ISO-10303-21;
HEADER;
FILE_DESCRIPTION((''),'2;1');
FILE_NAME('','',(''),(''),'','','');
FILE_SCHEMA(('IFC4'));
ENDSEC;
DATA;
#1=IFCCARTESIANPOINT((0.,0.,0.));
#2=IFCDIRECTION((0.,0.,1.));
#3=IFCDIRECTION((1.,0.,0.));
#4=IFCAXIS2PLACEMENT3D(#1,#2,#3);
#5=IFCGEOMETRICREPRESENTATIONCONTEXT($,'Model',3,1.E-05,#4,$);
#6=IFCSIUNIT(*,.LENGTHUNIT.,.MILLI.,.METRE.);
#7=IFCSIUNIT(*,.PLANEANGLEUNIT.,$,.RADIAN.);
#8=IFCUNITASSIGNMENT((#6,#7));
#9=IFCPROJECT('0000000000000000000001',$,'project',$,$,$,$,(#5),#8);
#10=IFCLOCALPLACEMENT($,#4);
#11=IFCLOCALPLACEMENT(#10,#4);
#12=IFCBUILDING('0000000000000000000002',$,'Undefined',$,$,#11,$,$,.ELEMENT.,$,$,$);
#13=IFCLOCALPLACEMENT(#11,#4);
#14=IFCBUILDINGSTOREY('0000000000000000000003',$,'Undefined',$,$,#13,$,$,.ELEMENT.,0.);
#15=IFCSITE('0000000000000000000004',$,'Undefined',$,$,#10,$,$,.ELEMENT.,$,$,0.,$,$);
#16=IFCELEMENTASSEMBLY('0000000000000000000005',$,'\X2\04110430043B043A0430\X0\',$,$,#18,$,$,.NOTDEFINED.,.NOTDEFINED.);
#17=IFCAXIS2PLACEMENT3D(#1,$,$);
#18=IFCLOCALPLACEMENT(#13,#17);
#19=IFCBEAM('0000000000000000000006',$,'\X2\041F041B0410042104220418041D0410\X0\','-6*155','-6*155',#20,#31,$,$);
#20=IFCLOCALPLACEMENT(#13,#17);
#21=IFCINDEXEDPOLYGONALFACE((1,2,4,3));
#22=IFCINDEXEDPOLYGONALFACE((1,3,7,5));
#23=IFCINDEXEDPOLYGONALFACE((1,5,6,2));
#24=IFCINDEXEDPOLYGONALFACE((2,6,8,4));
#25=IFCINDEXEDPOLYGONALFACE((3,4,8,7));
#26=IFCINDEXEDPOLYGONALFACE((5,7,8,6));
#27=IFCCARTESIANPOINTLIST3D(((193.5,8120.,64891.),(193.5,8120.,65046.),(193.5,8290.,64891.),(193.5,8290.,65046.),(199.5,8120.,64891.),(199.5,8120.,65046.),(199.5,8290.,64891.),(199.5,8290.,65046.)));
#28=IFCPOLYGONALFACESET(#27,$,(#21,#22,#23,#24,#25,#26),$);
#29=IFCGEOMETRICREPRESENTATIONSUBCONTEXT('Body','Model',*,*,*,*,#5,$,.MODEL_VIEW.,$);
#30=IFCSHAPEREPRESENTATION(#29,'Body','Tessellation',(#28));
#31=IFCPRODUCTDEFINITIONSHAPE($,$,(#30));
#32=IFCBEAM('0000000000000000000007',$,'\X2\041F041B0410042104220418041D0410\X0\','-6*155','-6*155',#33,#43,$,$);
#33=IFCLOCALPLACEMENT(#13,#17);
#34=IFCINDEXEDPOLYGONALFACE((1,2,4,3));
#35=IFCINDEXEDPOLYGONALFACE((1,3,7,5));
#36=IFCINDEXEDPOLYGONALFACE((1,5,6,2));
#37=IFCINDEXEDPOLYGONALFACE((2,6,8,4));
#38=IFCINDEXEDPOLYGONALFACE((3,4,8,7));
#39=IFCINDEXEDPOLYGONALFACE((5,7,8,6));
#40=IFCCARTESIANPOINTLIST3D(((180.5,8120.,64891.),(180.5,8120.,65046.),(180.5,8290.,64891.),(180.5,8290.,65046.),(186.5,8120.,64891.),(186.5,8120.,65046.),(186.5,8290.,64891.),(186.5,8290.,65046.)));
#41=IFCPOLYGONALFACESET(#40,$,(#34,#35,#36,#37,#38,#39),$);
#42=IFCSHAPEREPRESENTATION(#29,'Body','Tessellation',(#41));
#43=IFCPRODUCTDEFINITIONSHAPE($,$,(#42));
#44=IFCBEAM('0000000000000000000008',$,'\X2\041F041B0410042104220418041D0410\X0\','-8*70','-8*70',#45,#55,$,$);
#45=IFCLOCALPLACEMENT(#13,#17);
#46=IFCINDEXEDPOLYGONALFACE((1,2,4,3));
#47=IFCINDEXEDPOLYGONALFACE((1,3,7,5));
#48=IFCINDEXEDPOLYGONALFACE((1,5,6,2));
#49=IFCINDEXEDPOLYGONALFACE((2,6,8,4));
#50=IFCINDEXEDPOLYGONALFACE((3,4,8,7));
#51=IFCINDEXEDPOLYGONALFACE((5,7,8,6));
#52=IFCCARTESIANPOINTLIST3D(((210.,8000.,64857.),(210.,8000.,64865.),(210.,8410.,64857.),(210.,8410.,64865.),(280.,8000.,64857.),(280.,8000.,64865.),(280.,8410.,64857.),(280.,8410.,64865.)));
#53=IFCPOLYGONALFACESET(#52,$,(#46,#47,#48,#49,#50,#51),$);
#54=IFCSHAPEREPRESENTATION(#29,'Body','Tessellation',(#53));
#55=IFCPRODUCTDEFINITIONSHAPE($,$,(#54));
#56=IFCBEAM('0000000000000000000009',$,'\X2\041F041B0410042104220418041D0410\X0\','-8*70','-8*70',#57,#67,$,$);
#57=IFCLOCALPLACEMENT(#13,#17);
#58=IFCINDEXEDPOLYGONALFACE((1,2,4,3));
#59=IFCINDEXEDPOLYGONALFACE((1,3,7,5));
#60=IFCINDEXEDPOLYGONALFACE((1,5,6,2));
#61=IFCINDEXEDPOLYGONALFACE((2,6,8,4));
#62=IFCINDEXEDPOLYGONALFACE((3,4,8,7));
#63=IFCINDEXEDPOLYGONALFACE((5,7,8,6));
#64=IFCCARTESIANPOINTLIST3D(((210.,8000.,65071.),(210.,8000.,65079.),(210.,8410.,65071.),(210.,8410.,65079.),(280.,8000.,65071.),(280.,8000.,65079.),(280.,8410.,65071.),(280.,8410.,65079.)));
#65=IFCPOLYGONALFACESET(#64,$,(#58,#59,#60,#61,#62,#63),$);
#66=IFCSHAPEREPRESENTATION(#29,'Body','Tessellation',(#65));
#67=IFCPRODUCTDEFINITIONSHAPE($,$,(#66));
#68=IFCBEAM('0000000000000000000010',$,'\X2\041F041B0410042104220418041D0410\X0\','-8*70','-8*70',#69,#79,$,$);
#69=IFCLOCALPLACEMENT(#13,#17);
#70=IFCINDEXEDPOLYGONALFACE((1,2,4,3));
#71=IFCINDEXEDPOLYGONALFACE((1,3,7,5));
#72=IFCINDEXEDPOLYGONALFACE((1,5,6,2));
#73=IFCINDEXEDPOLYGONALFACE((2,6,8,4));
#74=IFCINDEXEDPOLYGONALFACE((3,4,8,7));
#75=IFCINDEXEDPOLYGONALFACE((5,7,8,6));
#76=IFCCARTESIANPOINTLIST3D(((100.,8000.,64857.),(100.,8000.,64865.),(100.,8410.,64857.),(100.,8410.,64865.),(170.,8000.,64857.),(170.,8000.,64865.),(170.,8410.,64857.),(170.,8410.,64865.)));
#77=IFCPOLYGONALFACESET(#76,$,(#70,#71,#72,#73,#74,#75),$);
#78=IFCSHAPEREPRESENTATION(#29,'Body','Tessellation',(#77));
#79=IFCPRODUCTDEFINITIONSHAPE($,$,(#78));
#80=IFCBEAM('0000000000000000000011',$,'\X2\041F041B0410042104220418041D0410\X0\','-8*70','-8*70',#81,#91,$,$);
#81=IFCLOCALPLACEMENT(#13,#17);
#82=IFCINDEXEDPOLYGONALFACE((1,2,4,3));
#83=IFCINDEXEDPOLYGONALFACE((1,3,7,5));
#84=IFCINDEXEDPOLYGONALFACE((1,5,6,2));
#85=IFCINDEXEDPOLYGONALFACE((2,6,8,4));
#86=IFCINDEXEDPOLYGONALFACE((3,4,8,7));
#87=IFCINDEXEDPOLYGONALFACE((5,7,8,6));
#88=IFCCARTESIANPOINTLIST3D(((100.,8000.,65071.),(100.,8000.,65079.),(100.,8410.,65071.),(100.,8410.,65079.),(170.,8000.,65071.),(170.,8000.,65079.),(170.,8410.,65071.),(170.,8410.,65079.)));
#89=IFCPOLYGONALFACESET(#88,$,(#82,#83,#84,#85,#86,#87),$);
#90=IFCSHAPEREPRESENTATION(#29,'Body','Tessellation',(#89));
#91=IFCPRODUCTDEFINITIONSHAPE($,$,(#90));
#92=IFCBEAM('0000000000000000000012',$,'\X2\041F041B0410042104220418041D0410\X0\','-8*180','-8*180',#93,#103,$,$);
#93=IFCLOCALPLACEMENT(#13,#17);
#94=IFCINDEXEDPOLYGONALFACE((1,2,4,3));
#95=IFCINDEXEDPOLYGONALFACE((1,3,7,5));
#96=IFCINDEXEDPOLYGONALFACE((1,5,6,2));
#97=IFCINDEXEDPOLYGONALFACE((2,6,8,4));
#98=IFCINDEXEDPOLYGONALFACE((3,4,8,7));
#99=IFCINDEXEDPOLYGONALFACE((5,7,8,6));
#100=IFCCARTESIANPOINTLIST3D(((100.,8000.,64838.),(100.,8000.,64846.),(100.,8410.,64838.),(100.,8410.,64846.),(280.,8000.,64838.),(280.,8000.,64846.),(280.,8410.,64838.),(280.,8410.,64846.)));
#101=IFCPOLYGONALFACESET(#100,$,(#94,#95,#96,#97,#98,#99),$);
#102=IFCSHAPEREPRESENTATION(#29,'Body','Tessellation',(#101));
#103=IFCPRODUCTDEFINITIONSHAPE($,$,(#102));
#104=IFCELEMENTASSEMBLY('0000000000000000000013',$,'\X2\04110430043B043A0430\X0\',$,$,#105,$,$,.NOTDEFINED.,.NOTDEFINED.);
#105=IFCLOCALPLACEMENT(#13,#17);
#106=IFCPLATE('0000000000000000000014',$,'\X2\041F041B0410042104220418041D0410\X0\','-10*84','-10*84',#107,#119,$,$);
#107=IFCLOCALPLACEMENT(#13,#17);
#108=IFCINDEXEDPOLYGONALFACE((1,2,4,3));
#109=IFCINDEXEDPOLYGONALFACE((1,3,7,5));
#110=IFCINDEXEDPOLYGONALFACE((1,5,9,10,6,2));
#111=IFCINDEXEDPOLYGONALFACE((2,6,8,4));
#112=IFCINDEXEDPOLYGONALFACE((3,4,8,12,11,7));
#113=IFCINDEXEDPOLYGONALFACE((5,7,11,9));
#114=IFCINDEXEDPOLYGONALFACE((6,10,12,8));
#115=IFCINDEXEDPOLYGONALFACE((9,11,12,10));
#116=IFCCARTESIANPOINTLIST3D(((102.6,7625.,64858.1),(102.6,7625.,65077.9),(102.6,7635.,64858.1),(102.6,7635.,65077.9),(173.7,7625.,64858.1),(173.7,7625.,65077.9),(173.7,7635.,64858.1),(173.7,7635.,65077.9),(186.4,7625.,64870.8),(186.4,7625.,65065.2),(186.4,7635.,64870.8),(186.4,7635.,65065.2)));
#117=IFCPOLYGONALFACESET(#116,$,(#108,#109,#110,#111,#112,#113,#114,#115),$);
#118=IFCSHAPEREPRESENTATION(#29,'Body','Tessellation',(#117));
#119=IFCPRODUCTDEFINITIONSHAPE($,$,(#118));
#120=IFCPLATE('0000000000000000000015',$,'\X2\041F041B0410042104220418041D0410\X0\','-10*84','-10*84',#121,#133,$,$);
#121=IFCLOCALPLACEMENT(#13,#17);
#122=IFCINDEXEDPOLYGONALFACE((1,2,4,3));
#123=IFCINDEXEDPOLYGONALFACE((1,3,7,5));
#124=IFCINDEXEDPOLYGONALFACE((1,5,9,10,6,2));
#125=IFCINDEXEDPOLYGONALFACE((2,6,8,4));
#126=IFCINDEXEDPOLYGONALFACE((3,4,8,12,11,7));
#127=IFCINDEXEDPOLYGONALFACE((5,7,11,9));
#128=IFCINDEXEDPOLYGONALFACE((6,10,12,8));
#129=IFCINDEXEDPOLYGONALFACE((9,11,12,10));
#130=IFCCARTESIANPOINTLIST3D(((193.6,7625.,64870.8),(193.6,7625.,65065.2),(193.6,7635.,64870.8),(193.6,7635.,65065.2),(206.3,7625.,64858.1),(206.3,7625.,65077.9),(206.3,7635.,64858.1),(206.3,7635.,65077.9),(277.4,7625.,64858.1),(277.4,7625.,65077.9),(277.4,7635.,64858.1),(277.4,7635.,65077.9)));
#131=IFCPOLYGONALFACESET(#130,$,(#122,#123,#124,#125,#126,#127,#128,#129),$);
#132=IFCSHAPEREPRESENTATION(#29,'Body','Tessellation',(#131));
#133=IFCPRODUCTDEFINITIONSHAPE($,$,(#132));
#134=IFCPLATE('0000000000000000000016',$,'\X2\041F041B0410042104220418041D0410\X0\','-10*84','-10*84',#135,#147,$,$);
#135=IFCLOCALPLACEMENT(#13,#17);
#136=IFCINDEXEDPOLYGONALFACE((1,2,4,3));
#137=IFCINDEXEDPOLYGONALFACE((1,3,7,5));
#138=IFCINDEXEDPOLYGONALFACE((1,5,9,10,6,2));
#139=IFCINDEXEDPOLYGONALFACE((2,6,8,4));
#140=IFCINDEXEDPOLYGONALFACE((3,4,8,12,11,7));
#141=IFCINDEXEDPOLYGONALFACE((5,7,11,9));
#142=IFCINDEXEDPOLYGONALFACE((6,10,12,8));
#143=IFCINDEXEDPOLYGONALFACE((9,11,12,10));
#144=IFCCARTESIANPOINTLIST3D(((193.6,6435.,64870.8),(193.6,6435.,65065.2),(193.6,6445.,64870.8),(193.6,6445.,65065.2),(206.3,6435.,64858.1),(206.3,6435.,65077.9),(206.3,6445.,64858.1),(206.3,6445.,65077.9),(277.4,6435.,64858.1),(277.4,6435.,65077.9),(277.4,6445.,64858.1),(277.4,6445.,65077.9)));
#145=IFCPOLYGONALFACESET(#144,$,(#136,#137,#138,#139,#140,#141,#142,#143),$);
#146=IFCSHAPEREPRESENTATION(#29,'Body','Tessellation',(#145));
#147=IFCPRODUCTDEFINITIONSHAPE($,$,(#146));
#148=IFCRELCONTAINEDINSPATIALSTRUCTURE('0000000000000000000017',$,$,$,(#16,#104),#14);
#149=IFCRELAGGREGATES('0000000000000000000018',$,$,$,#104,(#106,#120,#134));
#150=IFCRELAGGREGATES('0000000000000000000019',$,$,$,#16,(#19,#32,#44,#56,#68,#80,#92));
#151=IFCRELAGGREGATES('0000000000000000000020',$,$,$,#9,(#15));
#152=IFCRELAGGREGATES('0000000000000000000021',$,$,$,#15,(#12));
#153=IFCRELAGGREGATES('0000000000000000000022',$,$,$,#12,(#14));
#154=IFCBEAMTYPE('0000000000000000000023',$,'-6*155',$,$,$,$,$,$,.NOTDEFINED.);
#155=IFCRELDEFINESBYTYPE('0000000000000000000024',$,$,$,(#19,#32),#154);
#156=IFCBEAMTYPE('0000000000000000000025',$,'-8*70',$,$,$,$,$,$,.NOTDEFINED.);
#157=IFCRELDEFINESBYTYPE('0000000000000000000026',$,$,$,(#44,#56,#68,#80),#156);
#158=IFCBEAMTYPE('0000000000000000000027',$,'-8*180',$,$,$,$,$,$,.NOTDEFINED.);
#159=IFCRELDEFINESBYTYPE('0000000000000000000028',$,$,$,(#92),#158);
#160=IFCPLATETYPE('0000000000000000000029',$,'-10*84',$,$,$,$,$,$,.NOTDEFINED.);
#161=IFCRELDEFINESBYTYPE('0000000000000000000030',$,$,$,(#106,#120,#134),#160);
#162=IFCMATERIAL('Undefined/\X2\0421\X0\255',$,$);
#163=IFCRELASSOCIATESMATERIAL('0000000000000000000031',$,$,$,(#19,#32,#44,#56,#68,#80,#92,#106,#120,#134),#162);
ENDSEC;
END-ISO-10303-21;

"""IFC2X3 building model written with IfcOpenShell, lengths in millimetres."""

from ifc_helpers import new_model, si_unit, frame, origin_with_axes, origin_2d_with_axis, place, context, subcontext, project, spatial, polyline, rectangle, outline, extrude, material, type_object, element, aggregate, save


model = new_model("IFC2X3")

# Units and contexts
model_context = context("Model", 3, precision=1e-05, world=origin_with_axes())
body_context = subcontext(model_context, "Body", "Model", "MODEL_VIEW")
ifc_project = project(units=[si_unit("LENGTHUNIT", "METRE", prefix="MILLI"), si_unit("PLANEANGLEUNIT", "RADIAN")], contexts=[model_context])

# Site, building, storey
site_placement = place(None, origin_with_axes())
site = spatial("IfcSite", under=ifc_project, at=site_placement, Name="Undefined", CompositionType="ELEMENT", RefElevation=0.0)
building_placement = place(site_placement, origin_with_axes())
building = spatial("IfcBuilding", under=site, at=building_placement, Name="Undefined", CompositionType="ELEMENT")
storey_placement = place(building_placement, origin_with_axes())
storey = spatial("IfcBuildingStorey", under=building, at=storey_placement, Name="Undefined", CompositionType="ELEMENT", Elevation=0.0)

# Element assembly, beams
assembly_1_placement = place(storey_placement, origin_with_axes())
assembly_1 = element("IfcElementAssembly", 1, at=assembly_1_placement, inside=storey, Name="Балка", AssemblyPlace="NOTDEFINED", PredefinedType="NOTDEFINED")
ifc_material_1 = material(Name="Undefined/С255")
beam_type_1 = type_object("IfcBeamType", Name="-6*155", PredefinedType="NOTDEFINED")
beam_1_placement = place(assembly_1_placement, frame((196.5, 8290.0, 64968.5), z_axis=(0.0, 0.0, 1.0), x_axis=(0.0, -1.0, 0.0)))
beam_1 = element("IfcBeam", 2, at=beam_1_placement, type_object=beam_type_1, material=ifc_material_1, Name="ПЛАСТИНА", Description="-6*155", ObjectType="-6*155", context=body_context, shape_type="SweptSolid", body=[
    extrude(rectangle(XDim=6.0, YDim=155.0, at=origin_2d_with_axis()), frame((170.0, 0.0, 0.0), z_axis=(-1.0, 0.0, 0.0), x_axis=(0.0, -1.0, 0.0)), (0.0, 0.0, 1.0), 170.0),
])
beam_2_placement = place(assembly_1_placement, frame((183.5, 8290.0, 64968.5), z_axis=(0.0, 0.0, 1.0), x_axis=(0.0, -1.0, 0.0)))
beam_2 = element("IfcBeam", 3, at=beam_2_placement, type_object=beam_type_1, material=ifc_material_1, Name="ПЛАСТИНА", Description="-6*155", ObjectType="-6*155", context=body_context, shape_type="SweptSolid", body=[
    extrude(rectangle(XDim=6.0, YDim=155.0, at=origin_2d_with_axis()), frame((170.0, 0.0, 0.0), z_axis=(-1.0, 0.0, 0.0), x_axis=(0.0, -1.0, 0.0)), (0.0, 0.0, 1.0), 170.0),
])
beam_type_2 = type_object("IfcBeamType", Name="-8*70", PredefinedType="NOTDEFINED")
beam_3_placement = place(assembly_1_placement, frame((245.0, 8000.0, 64861.0), z_axis=(-1.0, 0.0, 0.0), x_axis=(0.0, 1.0, 0.0)))
beam_3 = element("IfcBeam", 4, at=beam_3_placement, type_object=beam_type_2, material=ifc_material_1, Name="ПЛАСТИНА", Description="-8*70", ObjectType="-8*70", context=body_context, shape_type="SweptSolid", body=[
    extrude(rectangle(XDim=8.0, YDim=70.0, at=origin_2d_with_axis()), frame((410.0, 0.0, 0.0), z_axis=(-1.0, 0.0, 0.0), x_axis=(0.0, -1.0, 0.0)), (0.0, 0.0, 1.0), 410.0),
])
beam_4_placement = place(assembly_1_placement, frame((245.0, 8000.0, 65075.0), z_axis=(-1.0, 0.0, 0.0), x_axis=(0.0, 1.0, 0.0)))
beam_4 = element("IfcBeam", 5, at=beam_4_placement, type_object=beam_type_2, material=ifc_material_1, Name="ПЛАСТИНА", Description="-8*70", ObjectType="-8*70", context=body_context, shape_type="SweptSolid", body=[
    extrude(rectangle(XDim=8.0, YDim=70.0, at=origin_2d_with_axis()), frame((410.0, 0.0, 0.0), z_axis=(-1.0, 0.0, 0.0), x_axis=(0.0, -1.0, 0.0)), (0.0, 0.0, 1.0), 410.0),
])
beam_5_placement = place(assembly_1_placement, frame((135.0, 8000.0, 64861.0), z_axis=(-1.0, 0.0, 0.0), x_axis=(0.0, 1.0, 0.0)))
beam_5 = element("IfcBeam", 6, at=beam_5_placement, type_object=beam_type_2, material=ifc_material_1, Name="ПЛАСТИНА", Description="-8*70", ObjectType="-8*70", context=body_context, shape_type="SweptSolid", body=[
    extrude(rectangle(XDim=8.0, YDim=70.0, at=origin_2d_with_axis()), frame((410.0, 0.0, 0.0), z_axis=(-1.0, 0.0, 0.0), x_axis=(0.0, -1.0, 0.0)), (0.0, 0.0, 1.0), 410.0),
])
beam_6_placement = place(assembly_1_placement, frame((135.0, 8000.0, 65075.0), z_axis=(-1.0, 0.0, 0.0), x_axis=(0.0, 1.0, 0.0)))
beam_6 = element("IfcBeam", 7, at=beam_6_placement, type_object=beam_type_2, material=ifc_material_1, Name="ПЛАСТИНА", Description="-8*70", ObjectType="-8*70", context=body_context, shape_type="SweptSolid", body=[
    extrude(rectangle(XDim=8.0, YDim=70.0, at=origin_2d_with_axis()), frame((410.0, 0.0, 0.0), z_axis=(-1.0, 0.0, 0.0), x_axis=(0.0, -1.0, 0.0)), (0.0, 0.0, 1.0), 410.0),
])
beam_type_3 = type_object("IfcBeamType", Name="-8*180", PredefinedType="NOTDEFINED")
beam_7_placement = place(assembly_1_placement, frame((190.0, 8410.0, 64842.0), z_axis=(-1.0, 0.0, 0.0), x_axis=(0.0, -1.0, 0.0)))
beam_7 = element("IfcBeam", 8, at=beam_7_placement, type_object=beam_type_3, material=ifc_material_1, Name="ПЛАСТИНА", Description="-8*180", ObjectType="-8*180", context=body_context, shape_type="SweptSolid", body=[
    extrude(rectangle(XDim=8.0, YDim=180.0, at=origin_2d_with_axis()), frame((410.0, 0.0, 0.0), z_axis=(-1.0, 0.0, 0.0), x_axis=(0.0, -1.0, 0.0)), (0.0, 0.0, 1.0), 410.0),
])

# Element assembly, plates
assembly_2_placement = place(storey_placement, origin_with_axes())
assembly_2 = element("IfcElementAssembly", 9, at=assembly_2_placement, inside=storey, Name="Балка", AssemblyPlace="NOTDEFINED", PredefinedType="NOTDEFINED")
plate_type = type_object("IfcPlateType", Name="-10*84", PredefinedType="NOTDEFINED")
plate_1_placement = place(assembly_2_placement, frame((186.4, 7630.0, 65077.9), z_axis=(0.0, -1.0, 0.0), x_axis=(-1.0, 0.0, 0.0)))
plate_1 = element("IfcPlate", 10, at=plate_1_placement, type_object=plate_type, material=ifc_material_1, Name="ПЛАСТИНА", Description="-10*84", ObjectType="-10*84", context=body_context, shape_type="SweptSolid", body=[
    extrude(outline(polyline([(0.0, 12.7), (12.7, 0.0), (83.8, 0.0), (83.8, 219.8), (12.7, 219.8), (0.0, 207.1), (0.0, 12.7)])), frame((0.0, 0.0, -5.0), z_axis=(0.0, 0.0, 1.0), x_axis=(1.0, 0.0, 0.0)), (0.0, 0.0, 1.0), 10.0),
])
plate_2_placement = place(assembly_2_placement, frame((277.4, 7630.0, 65077.9), z_axis=(0.0, -1.0, 0.0), x_axis=(-1.0, 0.0, 0.0)))
plate_2 = element("IfcPlate", 11, at=plate_2_placement, type_object=plate_type, material=ifc_material_1, Name="ПЛАСТИНА", Description="-10*84", ObjectType="-10*84", context=body_context, shape_type="SweptSolid", body=[
    extrude(outline(polyline([(0.0, 0.0), (71.1, 0.0), (83.8, 12.7), (83.8, 207.1), (71.1, 219.8), (0.0, 219.8), (0.0, 0.0)])), frame((0.0, 0.0, -5.0), z_axis=(0.0, 0.0, 1.0), x_axis=(1.0, 0.0, 0.0)), (0.0, 0.0, 1.0), 10.0),
])
plate_3_placement = place(assembly_2_placement, frame((277.4, 6440.0, 65077.9), z_axis=(0.0, -1.0, 0.0), x_axis=(-1.0, 0.0, 0.0)))
plate_3 = element("IfcPlate", 12, at=plate_3_placement, type_object=plate_type, material=ifc_material_1, Name="ПЛАСТИНА", Description="-10*84", ObjectType="-10*84", context=body_context, shape_type="SweptSolid", body=[
    extrude(outline(polyline([(0.0, 0.0), (71.1, 0.0), (83.8, 12.7), (83.8, 207.1), (71.1, 219.8), (0.0, 219.8), (0.0, 0.0)])), frame((0.0, 0.0, -5.0), z_axis=(0.0, 0.0, 1.0), x_axis=(1.0, 0.0, 0.0)), (0.0, 0.0, 1.0), 10.0),
])
aggregate(assembly_2, [plate_1, plate_2, plate_3])

aggregate(assembly_1, [beam_1, beam_2, beam_3, beam_4, beam_5, beam_6, beam_7])

save(model, "model.ifc")
